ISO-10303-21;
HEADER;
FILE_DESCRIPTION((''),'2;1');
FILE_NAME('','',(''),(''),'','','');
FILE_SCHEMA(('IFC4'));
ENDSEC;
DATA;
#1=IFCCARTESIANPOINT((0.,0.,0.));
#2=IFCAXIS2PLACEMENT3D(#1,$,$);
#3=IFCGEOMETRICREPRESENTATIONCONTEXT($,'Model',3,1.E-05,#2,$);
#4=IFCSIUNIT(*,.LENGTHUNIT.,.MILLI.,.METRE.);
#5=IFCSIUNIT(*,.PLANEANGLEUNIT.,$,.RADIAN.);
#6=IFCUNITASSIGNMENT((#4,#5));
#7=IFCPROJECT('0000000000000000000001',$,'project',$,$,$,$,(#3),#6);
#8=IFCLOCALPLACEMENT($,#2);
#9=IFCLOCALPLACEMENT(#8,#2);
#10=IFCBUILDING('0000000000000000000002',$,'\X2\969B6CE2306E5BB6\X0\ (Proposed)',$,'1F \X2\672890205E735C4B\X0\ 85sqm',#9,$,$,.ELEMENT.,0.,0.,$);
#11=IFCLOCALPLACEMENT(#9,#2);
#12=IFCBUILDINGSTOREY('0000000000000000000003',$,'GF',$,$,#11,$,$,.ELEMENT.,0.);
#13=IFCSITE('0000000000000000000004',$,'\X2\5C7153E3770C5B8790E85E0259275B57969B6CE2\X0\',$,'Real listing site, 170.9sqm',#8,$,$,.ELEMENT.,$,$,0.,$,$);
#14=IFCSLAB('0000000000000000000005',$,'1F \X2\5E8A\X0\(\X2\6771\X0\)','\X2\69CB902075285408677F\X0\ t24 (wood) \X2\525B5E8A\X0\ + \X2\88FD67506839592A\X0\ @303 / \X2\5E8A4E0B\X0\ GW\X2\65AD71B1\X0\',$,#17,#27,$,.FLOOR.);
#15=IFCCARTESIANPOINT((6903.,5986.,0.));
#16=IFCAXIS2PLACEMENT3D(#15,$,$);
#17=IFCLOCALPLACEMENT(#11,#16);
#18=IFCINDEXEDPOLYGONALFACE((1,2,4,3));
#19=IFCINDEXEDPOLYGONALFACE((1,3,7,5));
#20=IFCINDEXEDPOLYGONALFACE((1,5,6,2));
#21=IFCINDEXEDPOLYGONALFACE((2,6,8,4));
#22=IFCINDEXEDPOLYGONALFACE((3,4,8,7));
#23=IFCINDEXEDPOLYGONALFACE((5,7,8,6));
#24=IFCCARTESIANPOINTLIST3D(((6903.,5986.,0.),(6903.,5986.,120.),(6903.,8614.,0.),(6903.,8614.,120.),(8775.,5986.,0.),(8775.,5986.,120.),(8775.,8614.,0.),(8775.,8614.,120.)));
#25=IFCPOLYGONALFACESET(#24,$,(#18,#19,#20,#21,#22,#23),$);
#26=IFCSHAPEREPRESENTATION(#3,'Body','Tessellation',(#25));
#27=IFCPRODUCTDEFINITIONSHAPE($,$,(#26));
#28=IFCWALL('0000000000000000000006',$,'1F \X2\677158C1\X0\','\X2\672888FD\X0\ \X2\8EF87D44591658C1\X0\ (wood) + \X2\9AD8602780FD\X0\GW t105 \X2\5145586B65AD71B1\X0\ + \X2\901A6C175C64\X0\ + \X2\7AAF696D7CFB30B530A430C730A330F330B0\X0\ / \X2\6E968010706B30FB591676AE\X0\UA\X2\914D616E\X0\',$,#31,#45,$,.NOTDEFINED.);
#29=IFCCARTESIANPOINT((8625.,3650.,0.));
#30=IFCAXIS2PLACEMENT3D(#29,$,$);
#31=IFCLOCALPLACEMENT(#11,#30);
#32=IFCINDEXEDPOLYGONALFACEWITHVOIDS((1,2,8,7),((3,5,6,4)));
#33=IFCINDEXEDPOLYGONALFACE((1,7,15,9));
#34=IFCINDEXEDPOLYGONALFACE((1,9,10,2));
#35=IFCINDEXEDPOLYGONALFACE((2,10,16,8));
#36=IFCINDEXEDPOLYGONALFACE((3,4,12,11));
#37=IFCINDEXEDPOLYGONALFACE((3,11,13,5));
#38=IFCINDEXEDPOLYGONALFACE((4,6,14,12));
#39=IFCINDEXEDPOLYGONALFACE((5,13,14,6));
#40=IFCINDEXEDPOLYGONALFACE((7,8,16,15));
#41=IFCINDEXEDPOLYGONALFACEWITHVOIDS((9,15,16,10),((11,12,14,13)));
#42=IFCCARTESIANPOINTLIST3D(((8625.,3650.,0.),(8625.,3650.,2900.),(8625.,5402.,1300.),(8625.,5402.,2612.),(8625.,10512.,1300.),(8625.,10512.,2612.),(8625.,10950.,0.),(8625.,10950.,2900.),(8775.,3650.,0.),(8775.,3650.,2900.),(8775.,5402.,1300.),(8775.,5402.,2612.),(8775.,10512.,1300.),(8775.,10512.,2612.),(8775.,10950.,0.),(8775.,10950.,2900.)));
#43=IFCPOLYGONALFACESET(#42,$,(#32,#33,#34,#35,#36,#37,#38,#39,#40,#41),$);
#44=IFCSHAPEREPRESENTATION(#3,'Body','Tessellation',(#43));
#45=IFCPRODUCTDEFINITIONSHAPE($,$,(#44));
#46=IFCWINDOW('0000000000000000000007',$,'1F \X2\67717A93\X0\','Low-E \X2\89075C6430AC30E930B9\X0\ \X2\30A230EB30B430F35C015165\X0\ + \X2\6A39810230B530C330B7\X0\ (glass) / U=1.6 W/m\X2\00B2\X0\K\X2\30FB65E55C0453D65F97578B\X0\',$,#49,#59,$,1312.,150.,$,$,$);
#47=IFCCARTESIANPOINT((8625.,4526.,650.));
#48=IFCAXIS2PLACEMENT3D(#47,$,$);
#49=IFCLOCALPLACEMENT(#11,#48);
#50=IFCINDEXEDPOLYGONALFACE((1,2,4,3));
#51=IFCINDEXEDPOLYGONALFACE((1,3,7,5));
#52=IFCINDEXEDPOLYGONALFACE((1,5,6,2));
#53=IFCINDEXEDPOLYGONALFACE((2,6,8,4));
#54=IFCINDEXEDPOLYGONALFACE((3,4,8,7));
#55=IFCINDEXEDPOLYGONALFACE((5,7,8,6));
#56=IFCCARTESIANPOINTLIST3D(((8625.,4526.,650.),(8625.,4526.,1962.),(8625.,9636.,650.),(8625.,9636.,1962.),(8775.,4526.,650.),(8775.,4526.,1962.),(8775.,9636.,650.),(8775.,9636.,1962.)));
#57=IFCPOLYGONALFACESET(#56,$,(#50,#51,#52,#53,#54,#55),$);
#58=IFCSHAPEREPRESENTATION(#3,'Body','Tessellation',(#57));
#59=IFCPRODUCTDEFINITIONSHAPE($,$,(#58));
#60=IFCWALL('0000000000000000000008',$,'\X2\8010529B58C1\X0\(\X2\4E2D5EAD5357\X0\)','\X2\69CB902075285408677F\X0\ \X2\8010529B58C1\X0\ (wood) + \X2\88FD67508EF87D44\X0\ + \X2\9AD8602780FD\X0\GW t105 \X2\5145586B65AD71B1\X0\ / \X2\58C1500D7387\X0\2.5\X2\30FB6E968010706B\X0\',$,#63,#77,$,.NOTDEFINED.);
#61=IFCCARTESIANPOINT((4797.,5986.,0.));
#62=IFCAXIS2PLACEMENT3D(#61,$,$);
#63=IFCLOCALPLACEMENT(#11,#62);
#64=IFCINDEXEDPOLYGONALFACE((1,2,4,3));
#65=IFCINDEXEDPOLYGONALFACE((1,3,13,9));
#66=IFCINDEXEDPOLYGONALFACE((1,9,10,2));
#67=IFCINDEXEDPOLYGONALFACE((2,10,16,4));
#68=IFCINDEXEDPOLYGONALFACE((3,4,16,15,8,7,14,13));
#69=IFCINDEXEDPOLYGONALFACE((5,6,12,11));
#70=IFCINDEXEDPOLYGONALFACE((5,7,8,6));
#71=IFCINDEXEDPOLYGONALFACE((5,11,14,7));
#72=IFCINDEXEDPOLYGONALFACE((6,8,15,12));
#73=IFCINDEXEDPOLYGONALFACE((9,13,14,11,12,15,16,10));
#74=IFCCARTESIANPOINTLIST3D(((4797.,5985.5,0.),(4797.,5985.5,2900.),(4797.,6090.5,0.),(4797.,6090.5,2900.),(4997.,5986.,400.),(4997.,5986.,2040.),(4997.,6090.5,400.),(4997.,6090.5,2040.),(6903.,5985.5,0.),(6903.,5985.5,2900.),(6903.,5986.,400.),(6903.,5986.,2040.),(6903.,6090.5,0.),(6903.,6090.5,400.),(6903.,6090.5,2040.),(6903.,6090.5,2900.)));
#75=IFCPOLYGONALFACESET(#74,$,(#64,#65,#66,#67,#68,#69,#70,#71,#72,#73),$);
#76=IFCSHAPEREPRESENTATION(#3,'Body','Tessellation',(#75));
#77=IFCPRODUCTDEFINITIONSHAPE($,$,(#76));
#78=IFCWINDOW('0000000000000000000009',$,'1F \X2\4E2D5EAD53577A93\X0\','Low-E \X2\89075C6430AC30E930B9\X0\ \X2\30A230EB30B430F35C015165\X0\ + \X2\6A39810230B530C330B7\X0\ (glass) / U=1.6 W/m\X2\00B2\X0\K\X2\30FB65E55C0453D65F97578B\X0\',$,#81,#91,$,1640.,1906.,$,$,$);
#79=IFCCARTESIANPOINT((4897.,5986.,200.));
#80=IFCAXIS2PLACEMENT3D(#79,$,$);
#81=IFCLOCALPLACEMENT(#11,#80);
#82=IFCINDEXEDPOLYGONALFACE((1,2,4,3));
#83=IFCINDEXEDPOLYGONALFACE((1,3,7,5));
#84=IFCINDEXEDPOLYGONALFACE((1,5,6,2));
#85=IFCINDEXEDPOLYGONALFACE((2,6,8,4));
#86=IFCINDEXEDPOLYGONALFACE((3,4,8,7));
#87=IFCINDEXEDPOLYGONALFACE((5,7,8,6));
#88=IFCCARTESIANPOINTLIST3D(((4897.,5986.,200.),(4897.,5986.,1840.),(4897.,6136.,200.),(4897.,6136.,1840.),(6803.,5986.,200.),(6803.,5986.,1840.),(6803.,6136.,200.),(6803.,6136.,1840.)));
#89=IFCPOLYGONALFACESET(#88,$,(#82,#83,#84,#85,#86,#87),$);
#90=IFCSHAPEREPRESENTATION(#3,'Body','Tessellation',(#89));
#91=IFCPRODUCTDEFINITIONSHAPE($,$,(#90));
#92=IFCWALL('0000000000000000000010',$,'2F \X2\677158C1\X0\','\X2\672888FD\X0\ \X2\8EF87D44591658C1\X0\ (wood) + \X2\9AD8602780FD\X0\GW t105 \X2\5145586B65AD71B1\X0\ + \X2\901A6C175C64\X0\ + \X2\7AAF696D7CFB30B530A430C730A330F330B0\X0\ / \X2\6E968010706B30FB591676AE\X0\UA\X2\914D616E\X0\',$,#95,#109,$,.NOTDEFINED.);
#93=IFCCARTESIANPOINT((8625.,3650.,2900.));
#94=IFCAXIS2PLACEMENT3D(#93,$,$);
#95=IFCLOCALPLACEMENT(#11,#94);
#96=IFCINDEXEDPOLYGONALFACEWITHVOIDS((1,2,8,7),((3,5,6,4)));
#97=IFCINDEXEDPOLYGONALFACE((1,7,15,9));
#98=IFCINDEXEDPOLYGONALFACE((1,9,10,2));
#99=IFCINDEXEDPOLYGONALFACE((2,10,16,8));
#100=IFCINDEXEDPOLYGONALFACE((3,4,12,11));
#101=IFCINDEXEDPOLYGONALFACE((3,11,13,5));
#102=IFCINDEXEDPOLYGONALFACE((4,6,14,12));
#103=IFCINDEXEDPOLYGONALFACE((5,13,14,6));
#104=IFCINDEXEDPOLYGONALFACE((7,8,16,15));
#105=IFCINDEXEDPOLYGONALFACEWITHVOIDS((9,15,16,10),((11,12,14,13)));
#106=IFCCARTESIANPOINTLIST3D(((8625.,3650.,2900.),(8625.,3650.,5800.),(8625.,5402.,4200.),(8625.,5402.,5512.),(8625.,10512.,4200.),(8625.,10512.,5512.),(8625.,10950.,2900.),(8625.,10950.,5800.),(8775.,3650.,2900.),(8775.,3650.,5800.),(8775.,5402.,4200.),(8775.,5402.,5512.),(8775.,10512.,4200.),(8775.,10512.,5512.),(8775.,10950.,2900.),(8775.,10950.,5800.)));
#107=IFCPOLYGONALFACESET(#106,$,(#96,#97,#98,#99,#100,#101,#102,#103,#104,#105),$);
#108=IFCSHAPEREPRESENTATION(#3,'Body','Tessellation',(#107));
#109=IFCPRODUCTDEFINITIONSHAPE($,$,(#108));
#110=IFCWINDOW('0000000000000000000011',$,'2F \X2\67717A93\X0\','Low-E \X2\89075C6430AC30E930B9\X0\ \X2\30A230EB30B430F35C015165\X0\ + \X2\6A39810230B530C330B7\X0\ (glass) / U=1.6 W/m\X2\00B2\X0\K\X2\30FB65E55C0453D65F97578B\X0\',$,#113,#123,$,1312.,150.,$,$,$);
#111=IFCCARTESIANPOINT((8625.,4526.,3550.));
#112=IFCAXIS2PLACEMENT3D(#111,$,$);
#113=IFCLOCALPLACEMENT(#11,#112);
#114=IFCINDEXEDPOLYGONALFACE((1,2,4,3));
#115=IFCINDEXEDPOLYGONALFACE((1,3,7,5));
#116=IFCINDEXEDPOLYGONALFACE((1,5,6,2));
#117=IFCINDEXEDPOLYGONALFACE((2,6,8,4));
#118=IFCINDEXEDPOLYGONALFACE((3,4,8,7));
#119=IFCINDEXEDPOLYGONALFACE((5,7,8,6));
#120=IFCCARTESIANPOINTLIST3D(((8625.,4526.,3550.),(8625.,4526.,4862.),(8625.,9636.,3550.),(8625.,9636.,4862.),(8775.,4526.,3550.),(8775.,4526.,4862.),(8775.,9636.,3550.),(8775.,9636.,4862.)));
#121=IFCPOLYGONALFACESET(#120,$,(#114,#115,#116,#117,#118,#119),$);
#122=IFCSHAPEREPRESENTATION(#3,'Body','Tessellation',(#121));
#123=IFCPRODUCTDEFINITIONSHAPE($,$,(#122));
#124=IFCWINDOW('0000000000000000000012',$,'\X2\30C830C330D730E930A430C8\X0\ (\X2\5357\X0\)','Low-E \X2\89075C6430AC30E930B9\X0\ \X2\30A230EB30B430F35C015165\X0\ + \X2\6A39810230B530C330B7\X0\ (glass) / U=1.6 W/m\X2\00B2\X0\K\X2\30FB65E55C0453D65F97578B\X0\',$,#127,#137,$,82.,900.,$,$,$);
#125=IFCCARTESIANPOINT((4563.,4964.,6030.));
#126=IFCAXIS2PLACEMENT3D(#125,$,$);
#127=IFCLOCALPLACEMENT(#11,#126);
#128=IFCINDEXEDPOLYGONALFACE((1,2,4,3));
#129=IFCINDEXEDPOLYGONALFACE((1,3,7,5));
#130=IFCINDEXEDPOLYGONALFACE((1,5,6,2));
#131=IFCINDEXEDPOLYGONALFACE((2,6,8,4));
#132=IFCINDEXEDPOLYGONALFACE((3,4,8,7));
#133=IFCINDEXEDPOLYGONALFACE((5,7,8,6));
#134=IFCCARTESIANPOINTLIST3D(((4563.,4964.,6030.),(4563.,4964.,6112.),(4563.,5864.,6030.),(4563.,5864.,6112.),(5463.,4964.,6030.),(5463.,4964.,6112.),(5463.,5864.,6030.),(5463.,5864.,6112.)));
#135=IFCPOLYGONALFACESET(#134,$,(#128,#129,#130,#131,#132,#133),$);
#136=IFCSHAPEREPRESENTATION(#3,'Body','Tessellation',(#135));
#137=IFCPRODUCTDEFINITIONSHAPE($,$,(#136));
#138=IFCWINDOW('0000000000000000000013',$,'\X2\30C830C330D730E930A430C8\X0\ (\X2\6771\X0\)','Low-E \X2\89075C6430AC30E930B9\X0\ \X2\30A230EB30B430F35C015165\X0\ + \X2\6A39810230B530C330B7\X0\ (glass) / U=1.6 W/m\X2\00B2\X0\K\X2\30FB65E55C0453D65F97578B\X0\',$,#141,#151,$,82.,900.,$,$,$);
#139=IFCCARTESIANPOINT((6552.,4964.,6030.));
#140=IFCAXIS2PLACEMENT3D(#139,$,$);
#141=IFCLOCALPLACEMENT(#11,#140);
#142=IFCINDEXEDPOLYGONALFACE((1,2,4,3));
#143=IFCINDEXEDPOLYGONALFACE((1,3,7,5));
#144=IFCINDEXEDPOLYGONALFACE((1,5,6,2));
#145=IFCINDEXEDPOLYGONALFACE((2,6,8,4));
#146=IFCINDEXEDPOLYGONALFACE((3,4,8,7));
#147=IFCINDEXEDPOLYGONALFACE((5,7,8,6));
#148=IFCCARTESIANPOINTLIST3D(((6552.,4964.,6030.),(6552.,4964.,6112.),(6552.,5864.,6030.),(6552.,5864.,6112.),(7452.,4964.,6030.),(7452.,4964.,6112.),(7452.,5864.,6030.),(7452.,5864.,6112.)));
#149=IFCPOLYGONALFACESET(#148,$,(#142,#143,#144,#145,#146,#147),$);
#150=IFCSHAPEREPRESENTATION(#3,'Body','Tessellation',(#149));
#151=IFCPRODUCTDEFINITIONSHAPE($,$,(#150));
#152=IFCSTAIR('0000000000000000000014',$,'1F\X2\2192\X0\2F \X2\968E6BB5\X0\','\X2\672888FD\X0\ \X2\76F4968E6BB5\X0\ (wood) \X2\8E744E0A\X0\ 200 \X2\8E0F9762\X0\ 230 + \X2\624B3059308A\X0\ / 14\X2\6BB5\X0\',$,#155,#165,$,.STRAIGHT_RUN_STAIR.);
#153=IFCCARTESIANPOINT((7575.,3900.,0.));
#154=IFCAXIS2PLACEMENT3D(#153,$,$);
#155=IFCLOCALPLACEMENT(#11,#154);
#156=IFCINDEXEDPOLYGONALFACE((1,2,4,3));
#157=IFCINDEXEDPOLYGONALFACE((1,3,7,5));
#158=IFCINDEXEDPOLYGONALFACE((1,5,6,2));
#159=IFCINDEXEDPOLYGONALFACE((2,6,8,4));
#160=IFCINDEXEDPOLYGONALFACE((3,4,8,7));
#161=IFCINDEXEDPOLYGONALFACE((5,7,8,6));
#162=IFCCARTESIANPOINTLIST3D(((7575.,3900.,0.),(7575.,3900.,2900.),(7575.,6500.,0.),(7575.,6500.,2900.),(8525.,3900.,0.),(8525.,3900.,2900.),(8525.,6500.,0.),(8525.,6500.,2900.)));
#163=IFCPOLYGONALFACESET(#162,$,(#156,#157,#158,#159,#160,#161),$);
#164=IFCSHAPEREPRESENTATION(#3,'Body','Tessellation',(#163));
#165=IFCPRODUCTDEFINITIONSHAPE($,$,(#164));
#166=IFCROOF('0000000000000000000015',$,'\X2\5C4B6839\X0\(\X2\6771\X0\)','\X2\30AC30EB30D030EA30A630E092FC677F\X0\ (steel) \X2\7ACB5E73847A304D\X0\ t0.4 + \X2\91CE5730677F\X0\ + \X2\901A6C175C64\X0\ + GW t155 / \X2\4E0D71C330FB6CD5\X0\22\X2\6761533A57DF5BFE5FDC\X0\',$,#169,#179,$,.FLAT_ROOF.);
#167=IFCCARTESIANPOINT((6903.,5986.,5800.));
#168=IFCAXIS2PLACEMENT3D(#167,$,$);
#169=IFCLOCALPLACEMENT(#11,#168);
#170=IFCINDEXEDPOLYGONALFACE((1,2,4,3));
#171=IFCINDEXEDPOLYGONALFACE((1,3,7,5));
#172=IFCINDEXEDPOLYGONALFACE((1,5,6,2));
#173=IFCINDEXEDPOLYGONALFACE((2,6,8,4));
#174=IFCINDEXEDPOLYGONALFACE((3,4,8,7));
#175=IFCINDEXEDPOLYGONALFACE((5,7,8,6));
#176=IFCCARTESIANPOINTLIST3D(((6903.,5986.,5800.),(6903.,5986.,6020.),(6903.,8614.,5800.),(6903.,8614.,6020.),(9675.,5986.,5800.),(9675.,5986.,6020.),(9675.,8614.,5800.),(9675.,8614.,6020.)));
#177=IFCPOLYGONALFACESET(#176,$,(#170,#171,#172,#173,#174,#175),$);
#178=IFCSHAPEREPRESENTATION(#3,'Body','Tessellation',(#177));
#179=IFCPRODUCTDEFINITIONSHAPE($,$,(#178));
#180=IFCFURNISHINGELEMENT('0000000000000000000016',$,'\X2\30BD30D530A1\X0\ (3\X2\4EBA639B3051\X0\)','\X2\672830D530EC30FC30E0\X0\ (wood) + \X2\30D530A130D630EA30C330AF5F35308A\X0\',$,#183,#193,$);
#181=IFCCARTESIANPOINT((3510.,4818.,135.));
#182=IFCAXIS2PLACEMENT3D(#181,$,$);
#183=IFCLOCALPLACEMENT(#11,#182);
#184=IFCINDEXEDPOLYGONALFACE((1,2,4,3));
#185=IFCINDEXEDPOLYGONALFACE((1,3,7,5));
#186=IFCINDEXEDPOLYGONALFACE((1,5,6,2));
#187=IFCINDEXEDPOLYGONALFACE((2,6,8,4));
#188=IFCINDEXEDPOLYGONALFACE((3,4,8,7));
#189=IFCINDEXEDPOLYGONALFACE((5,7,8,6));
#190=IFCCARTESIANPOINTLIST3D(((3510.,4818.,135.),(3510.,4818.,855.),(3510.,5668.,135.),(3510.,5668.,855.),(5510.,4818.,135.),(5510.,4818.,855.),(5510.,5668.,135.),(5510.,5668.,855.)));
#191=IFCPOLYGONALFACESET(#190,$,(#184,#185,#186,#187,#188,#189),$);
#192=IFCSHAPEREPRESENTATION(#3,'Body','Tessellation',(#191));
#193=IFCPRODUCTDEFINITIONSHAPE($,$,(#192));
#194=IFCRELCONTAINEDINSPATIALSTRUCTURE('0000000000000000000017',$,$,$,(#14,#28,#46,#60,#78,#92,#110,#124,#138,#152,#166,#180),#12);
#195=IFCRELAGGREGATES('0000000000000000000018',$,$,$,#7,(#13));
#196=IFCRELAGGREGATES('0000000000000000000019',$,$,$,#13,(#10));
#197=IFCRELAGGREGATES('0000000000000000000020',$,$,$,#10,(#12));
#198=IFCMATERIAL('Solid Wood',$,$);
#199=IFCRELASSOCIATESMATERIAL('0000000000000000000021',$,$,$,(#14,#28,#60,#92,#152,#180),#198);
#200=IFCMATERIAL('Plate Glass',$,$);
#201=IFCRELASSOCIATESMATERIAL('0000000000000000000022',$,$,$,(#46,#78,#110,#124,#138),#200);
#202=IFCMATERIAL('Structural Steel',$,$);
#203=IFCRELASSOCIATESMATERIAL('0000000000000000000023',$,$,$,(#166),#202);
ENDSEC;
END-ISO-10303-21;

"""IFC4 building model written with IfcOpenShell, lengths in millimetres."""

from ifc_helpers import new_model, si_unit, frame, frame_2d, origin, place, context, project, spatial, rectangle, extrude, material, element, fill, save


model = new_model("IFC4")

# Units and contexts
model_context = context("Model", 3, precision=1e-05, world=origin())
ifc_project = project(units=[si_unit("LENGTHUNIT", "METRE", prefix="MILLI"), si_unit("PLANEANGLEUNIT", "RADIAN")], contexts=[model_context])

# Site, building, storey
site_placement = place(None, origin())
site = spatial("IfcSite", under=ifc_project, at=site_placement, Name="山口県宇部市大字際波", ObjectType="Real listing site, 170.9sqm", CompositionType="ELEMENT", RefElevation=0.0)
building_placement = place(site_placement, origin())
building = spatial("IfcBuilding", under=site, at=building_placement, Name="際波の家 (Proposed)", ObjectType="1F 木造平屋 85sqm", CompositionType="ELEMENT", ElevationOfRefHeight=0.0, ElevationOfTerrain=0.0)
storey_placement = place(building_placement, origin())
storey = spatial("IfcBuildingStorey", under=building, at=storey_placement, Name="GF", CompositionType="ELEMENT", Elevation=0.0)

# Slab
ifc_material_1 = material(Name="Solid Wood")
slab_placement = place(storey_placement, frame((6903.0, 5986.0, 0.0)))
element("IfcSlab", 1, at=slab_placement, inside=storey, material=ifc_material_1, Name="1F 床(東)", Description="構造用合板 t24 (wood) 剛床 + 製材根太 @303 / 床下 GW断熱", PredefinedType="FLOOR", context=model_context, shape_type="SweptSolid", body=[
    extrude(rectangle(XDim=1872.0, YDim=2628.0, at=frame_2d((936.0, 1314.0))), frame((6903.0, 5986.0, 0.0)), (0.0, 0.0, 1.0), 120.0),
])

# Walls, openings, windows
wall_1_placement = place(storey_placement, frame((8625.0, 3650.0, 0.0)))
wall_1 = element("IfcWall", 2, at=wall_1_placement, inside=storey, material=ifc_material_1, Name="1F 東壁", Description="木製 軸組外壁 (wood) + 高性能GW t105 充填断熱 + 通気層 + 窯業系サイディング / 準耐火・外皮UA配慮", PredefinedType="NOTDEFINED", context=model_context, shape_type="SweptSolid", body=[
    extrude(rectangle(XDim=150.0, YDim=7300.0, at=frame_2d((75.0, 3650.0))), frame((8625.0, 3650.0, 0.0)), (0.0, 0.0, 1.0), 2900.0),
])
opening_1_placement = place(storey_placement, frame((8625.0, 4526.0, 650.0)))
opening_1 = element("IfcOpeningElement", 3, at=opening_1_placement, cuts=wall_1, PredefinedType="NOTDEFINED", context=model_context, shape_type="SweptSolid", body=[
    extrude(rectangle(XDim=150.0, YDim=5110.0, at=frame_2d((75.0, 2555.0))), frame((8625.0, 4526.0, 650.0)), (0.0, 0.0, 1.0), 1312.0),
])
ifc_material_2 = material(Name="Plate Glass")
window_1_placement = place(storey_placement, frame((8625.0, 4526.0, 650.0)))
window_1 = element("IfcWindow", 4, at=window_1_placement, inside=storey, material=ifc_material_2, Name="1F 東窓", Description="Low-E 複層ガラス アルゴン封入 + 樹脂サッシ (glass) / U=1.6 W/m²K・日射取得型", OverallHeight=1312.0, OverallWidth=150.0, context=model_context, shape_type="SweptSolid", body=[
    extrude(rectangle(XDim=150.0, YDim=5110.0, at=frame_2d((75.0, 2555.0))), frame((8625.0, 4526.0, 650.0)), (0.0, 0.0, 1.0), 1312.0),
])
fill(opening_1, window_1)
wall_2_placement = place(storey_placement, frame((4797.0, 5986.0, 0.0)))
wall_2 = element("IfcWall", 5, at=wall_2_placement, inside=storey, material=ifc_material_1, Name="耐力壁(中庭南)", Description="構造用合板 耐力壁 (wood) + 製材軸組 + 高性能GW t105 充填断熱 / 壁倍率2.5・準耐火", PredefinedType="NOTDEFINED", context=model_context, shape_type="SweptSolid", body=[
    extrude(rectangle(XDim=2106.0, YDim=105.0, at=frame_2d((1053.0, 52.0))), frame((4797.0, 5986.0, 0.0)), (0.0, 0.0, 1.0), 2900.0),
])
opening_2_placement = place(storey_placement, frame((4897.0, 5986.0, 200.0)))
opening_2 = element("IfcOpeningElement", 6, at=opening_2_placement, cuts=wall_2, PredefinedType="NOTDEFINED", context=model_context, shape_type="SweptSolid", body=[
    extrude(rectangle(XDim=1906.0, YDim=150.0, at=frame_2d((953.0, 75.0))), frame((4897.0, 5986.0, 200.0)), (0.0, 0.0, 1.0), 1640.0),
])
window_2_placement = place(storey_placement, frame((4897.0, 5986.0, 200.0)))
window_2 = element("IfcWindow", 7, at=window_2_placement, inside=storey, material=ifc_material_2, Name="1F 中庭南窓", Description="Low-E 複層ガラス アルゴン封入 + 樹脂サッシ (glass) / U=1.6 W/m²K・日射取得型", OverallHeight=1640.0, OverallWidth=1906.0, context=model_context, shape_type="SweptSolid", body=[
    extrude(rectangle(XDim=1906.0, YDim=150.0, at=frame_2d((953.0, 75.0))), frame((4897.0, 5986.0, 200.0)), (0.0, 0.0, 1.0), 1640.0),
])
fill(opening_2, window_2)

# Wall, opening, window
wall_3_placement = place(storey_placement, frame((8625.0, 3650.0, 2900.0)))
wall_3 = element("IfcWall", 8, at=wall_3_placement, inside=storey, material=ifc_material_1, Name="2F 東壁", Description="木製 軸組外壁 (wood) + 高性能GW t105 充填断熱 + 通気層 + 窯業系サイディング / 準耐火・外皮UA配慮", PredefinedType="NOTDEFINED", context=model_context, shape_type="SweptSolid", body=[
    extrude(rectangle(XDim=150.0, YDim=7300.0, at=frame_2d((75.0, 3650.0))), frame((8625.0, 3650.0, 2900.0)), (0.0, 0.0, 1.0), 2900.0),
])
opening_3_placement = place(storey_placement, frame((8625.0, 4526.0, 3550.0)))
opening_3 = element("IfcOpeningElement", 9, at=opening_3_placement, cuts=wall_3, PredefinedType="NOTDEFINED", context=model_context, shape_type="SweptSolid", body=[
    extrude(rectangle(XDim=150.0, YDim=5110.0, at=frame_2d((75.0, 2555.0))), frame((8625.0, 4526.0, 3550.0)), (0.0, 0.0, 1.0), 1312.0),
])
window_3_placement = place(storey_placement, frame((8625.0, 4526.0, 3550.0)))
window_3 = element("IfcWindow", 10, at=window_3_placement, inside=storey, material=ifc_material_2, Name="2F 東窓", Description="Low-E 複層ガラス アルゴン封入 + 樹脂サッシ (glass) / U=1.6 W/m²K・日射取得型", OverallHeight=1312.0, OverallWidth=150.0, context=model_context, shape_type="SweptSolid", body=[
    extrude(rectangle(XDim=150.0, YDim=5110.0, at=frame_2d((75.0, 2555.0))), frame((8625.0, 4526.0, 3550.0)), (0.0, 0.0, 1.0), 1312.0),
])
fill(opening_3, window_3)

# Windows
window_4_placement = place(storey_placement, frame((4563.0, 4964.0, 6030.0)))
element("IfcWindow", 11, at=window_4_placement, inside=storey, material=ifc_material_2, Name="トップライト (南)", Description="Low-E 複層ガラス アルゴン封入 + 樹脂サッシ (glass) / U=1.6 W/m²K・日射取得型", OverallHeight=82.0, OverallWidth=900.0, context=model_context, shape_type="SweptSolid", body=[
    extrude(rectangle(XDim=900.0, YDim=900.0, at=frame_2d((450.0, 450.0))), frame((4563.0, 4964.0, 6030.0)), (0.0, 0.0, 1.0), 82.0),
])
window_5_placement = place(storey_placement, frame((6552.0, 4964.0, 6030.0)))
element("IfcWindow", 12, at=window_5_placement, inside=storey, material=ifc_material_2, Name="トップライト (東)", Description="Low-E 複層ガラス アルゴン封入 + 樹脂サッシ (glass) / U=1.6 W/m²K・日射取得型", OverallHeight=82.0, OverallWidth=900.0, context=model_context, shape_type="SweptSolid", body=[
    extrude(rectangle(XDim=900.0, YDim=900.0, at=frame_2d((450.0, 450.0))), frame((6552.0, 4964.0, 6030.0)), (0.0, 0.0, 1.0), 82.0),
])

# Stair
stair_placement = place(storey_placement, frame((7575.0, 3900.0, 0.0)))
element("IfcStair", 13, at=stair_placement, inside=storey, material=ifc_material_1, Name="1F→2F 階段", Description="木製 直階段 (wood) 蹴上 200 踏面 230 + 手すり / 14段", PredefinedType="STRAIGHT_RUN_STAIR", context=model_context, shape_type="SweptSolid", body=[
    extrude(rectangle(XDim=950.0, YDim=2600.0, at=frame_2d((475.0, 1300.0))), frame((7575.0, 3900.0, 0.0)), (0.0, 0.0, 1.0), 2900.0),
])

# Roof
ifc_material_3 = material(Name="Structural Steel")
roof_placement = place(storey_placement, frame((6903.0, 5986.0, 5800.0)))
element("IfcRoof", 14, at=roof_placement, inside=storey, material=ifc_material_3, Name="屋根(東)", Description="ガルバリウム鋼板 (steel) 立平葺き t0.4 + 野地板 + 通気層 + GW t155 / 不燃・法22条区域対応", PredefinedType="FLAT_ROOF", context=model_context, shape_type="SweptSolid", body=[
    extrude(rectangle(XDim=2772.0, YDim=2628.0, at=frame_2d((1386.0, 1314.0))), frame((6903.0, 5986.0, 5800.0)), (0.0, 0.0, 1.0), 220.0),
])

# Furnishing element
furnishing_1_placement = place(storey_placement, frame((3510.0, 4818.0, 135.0)))
element("IfcFurnishingElement", 15, at=furnishing_1_placement, inside=storey, material=ifc_material_1, Name="ソファ (3人掛け)", Description="木フレーム (wood) + ファブリック張り", context=model_context, shape_type="SweptSolid", body=[
    extrude(rectangle(XDim=2000.0, YDim=850.0, at=frame_2d((1000.0, 425.0))), frame((3510.0, 4818.0, 135.0)), (0.0, 0.0, 1.0), 720.0),
])

save(model, "model.ifc")
